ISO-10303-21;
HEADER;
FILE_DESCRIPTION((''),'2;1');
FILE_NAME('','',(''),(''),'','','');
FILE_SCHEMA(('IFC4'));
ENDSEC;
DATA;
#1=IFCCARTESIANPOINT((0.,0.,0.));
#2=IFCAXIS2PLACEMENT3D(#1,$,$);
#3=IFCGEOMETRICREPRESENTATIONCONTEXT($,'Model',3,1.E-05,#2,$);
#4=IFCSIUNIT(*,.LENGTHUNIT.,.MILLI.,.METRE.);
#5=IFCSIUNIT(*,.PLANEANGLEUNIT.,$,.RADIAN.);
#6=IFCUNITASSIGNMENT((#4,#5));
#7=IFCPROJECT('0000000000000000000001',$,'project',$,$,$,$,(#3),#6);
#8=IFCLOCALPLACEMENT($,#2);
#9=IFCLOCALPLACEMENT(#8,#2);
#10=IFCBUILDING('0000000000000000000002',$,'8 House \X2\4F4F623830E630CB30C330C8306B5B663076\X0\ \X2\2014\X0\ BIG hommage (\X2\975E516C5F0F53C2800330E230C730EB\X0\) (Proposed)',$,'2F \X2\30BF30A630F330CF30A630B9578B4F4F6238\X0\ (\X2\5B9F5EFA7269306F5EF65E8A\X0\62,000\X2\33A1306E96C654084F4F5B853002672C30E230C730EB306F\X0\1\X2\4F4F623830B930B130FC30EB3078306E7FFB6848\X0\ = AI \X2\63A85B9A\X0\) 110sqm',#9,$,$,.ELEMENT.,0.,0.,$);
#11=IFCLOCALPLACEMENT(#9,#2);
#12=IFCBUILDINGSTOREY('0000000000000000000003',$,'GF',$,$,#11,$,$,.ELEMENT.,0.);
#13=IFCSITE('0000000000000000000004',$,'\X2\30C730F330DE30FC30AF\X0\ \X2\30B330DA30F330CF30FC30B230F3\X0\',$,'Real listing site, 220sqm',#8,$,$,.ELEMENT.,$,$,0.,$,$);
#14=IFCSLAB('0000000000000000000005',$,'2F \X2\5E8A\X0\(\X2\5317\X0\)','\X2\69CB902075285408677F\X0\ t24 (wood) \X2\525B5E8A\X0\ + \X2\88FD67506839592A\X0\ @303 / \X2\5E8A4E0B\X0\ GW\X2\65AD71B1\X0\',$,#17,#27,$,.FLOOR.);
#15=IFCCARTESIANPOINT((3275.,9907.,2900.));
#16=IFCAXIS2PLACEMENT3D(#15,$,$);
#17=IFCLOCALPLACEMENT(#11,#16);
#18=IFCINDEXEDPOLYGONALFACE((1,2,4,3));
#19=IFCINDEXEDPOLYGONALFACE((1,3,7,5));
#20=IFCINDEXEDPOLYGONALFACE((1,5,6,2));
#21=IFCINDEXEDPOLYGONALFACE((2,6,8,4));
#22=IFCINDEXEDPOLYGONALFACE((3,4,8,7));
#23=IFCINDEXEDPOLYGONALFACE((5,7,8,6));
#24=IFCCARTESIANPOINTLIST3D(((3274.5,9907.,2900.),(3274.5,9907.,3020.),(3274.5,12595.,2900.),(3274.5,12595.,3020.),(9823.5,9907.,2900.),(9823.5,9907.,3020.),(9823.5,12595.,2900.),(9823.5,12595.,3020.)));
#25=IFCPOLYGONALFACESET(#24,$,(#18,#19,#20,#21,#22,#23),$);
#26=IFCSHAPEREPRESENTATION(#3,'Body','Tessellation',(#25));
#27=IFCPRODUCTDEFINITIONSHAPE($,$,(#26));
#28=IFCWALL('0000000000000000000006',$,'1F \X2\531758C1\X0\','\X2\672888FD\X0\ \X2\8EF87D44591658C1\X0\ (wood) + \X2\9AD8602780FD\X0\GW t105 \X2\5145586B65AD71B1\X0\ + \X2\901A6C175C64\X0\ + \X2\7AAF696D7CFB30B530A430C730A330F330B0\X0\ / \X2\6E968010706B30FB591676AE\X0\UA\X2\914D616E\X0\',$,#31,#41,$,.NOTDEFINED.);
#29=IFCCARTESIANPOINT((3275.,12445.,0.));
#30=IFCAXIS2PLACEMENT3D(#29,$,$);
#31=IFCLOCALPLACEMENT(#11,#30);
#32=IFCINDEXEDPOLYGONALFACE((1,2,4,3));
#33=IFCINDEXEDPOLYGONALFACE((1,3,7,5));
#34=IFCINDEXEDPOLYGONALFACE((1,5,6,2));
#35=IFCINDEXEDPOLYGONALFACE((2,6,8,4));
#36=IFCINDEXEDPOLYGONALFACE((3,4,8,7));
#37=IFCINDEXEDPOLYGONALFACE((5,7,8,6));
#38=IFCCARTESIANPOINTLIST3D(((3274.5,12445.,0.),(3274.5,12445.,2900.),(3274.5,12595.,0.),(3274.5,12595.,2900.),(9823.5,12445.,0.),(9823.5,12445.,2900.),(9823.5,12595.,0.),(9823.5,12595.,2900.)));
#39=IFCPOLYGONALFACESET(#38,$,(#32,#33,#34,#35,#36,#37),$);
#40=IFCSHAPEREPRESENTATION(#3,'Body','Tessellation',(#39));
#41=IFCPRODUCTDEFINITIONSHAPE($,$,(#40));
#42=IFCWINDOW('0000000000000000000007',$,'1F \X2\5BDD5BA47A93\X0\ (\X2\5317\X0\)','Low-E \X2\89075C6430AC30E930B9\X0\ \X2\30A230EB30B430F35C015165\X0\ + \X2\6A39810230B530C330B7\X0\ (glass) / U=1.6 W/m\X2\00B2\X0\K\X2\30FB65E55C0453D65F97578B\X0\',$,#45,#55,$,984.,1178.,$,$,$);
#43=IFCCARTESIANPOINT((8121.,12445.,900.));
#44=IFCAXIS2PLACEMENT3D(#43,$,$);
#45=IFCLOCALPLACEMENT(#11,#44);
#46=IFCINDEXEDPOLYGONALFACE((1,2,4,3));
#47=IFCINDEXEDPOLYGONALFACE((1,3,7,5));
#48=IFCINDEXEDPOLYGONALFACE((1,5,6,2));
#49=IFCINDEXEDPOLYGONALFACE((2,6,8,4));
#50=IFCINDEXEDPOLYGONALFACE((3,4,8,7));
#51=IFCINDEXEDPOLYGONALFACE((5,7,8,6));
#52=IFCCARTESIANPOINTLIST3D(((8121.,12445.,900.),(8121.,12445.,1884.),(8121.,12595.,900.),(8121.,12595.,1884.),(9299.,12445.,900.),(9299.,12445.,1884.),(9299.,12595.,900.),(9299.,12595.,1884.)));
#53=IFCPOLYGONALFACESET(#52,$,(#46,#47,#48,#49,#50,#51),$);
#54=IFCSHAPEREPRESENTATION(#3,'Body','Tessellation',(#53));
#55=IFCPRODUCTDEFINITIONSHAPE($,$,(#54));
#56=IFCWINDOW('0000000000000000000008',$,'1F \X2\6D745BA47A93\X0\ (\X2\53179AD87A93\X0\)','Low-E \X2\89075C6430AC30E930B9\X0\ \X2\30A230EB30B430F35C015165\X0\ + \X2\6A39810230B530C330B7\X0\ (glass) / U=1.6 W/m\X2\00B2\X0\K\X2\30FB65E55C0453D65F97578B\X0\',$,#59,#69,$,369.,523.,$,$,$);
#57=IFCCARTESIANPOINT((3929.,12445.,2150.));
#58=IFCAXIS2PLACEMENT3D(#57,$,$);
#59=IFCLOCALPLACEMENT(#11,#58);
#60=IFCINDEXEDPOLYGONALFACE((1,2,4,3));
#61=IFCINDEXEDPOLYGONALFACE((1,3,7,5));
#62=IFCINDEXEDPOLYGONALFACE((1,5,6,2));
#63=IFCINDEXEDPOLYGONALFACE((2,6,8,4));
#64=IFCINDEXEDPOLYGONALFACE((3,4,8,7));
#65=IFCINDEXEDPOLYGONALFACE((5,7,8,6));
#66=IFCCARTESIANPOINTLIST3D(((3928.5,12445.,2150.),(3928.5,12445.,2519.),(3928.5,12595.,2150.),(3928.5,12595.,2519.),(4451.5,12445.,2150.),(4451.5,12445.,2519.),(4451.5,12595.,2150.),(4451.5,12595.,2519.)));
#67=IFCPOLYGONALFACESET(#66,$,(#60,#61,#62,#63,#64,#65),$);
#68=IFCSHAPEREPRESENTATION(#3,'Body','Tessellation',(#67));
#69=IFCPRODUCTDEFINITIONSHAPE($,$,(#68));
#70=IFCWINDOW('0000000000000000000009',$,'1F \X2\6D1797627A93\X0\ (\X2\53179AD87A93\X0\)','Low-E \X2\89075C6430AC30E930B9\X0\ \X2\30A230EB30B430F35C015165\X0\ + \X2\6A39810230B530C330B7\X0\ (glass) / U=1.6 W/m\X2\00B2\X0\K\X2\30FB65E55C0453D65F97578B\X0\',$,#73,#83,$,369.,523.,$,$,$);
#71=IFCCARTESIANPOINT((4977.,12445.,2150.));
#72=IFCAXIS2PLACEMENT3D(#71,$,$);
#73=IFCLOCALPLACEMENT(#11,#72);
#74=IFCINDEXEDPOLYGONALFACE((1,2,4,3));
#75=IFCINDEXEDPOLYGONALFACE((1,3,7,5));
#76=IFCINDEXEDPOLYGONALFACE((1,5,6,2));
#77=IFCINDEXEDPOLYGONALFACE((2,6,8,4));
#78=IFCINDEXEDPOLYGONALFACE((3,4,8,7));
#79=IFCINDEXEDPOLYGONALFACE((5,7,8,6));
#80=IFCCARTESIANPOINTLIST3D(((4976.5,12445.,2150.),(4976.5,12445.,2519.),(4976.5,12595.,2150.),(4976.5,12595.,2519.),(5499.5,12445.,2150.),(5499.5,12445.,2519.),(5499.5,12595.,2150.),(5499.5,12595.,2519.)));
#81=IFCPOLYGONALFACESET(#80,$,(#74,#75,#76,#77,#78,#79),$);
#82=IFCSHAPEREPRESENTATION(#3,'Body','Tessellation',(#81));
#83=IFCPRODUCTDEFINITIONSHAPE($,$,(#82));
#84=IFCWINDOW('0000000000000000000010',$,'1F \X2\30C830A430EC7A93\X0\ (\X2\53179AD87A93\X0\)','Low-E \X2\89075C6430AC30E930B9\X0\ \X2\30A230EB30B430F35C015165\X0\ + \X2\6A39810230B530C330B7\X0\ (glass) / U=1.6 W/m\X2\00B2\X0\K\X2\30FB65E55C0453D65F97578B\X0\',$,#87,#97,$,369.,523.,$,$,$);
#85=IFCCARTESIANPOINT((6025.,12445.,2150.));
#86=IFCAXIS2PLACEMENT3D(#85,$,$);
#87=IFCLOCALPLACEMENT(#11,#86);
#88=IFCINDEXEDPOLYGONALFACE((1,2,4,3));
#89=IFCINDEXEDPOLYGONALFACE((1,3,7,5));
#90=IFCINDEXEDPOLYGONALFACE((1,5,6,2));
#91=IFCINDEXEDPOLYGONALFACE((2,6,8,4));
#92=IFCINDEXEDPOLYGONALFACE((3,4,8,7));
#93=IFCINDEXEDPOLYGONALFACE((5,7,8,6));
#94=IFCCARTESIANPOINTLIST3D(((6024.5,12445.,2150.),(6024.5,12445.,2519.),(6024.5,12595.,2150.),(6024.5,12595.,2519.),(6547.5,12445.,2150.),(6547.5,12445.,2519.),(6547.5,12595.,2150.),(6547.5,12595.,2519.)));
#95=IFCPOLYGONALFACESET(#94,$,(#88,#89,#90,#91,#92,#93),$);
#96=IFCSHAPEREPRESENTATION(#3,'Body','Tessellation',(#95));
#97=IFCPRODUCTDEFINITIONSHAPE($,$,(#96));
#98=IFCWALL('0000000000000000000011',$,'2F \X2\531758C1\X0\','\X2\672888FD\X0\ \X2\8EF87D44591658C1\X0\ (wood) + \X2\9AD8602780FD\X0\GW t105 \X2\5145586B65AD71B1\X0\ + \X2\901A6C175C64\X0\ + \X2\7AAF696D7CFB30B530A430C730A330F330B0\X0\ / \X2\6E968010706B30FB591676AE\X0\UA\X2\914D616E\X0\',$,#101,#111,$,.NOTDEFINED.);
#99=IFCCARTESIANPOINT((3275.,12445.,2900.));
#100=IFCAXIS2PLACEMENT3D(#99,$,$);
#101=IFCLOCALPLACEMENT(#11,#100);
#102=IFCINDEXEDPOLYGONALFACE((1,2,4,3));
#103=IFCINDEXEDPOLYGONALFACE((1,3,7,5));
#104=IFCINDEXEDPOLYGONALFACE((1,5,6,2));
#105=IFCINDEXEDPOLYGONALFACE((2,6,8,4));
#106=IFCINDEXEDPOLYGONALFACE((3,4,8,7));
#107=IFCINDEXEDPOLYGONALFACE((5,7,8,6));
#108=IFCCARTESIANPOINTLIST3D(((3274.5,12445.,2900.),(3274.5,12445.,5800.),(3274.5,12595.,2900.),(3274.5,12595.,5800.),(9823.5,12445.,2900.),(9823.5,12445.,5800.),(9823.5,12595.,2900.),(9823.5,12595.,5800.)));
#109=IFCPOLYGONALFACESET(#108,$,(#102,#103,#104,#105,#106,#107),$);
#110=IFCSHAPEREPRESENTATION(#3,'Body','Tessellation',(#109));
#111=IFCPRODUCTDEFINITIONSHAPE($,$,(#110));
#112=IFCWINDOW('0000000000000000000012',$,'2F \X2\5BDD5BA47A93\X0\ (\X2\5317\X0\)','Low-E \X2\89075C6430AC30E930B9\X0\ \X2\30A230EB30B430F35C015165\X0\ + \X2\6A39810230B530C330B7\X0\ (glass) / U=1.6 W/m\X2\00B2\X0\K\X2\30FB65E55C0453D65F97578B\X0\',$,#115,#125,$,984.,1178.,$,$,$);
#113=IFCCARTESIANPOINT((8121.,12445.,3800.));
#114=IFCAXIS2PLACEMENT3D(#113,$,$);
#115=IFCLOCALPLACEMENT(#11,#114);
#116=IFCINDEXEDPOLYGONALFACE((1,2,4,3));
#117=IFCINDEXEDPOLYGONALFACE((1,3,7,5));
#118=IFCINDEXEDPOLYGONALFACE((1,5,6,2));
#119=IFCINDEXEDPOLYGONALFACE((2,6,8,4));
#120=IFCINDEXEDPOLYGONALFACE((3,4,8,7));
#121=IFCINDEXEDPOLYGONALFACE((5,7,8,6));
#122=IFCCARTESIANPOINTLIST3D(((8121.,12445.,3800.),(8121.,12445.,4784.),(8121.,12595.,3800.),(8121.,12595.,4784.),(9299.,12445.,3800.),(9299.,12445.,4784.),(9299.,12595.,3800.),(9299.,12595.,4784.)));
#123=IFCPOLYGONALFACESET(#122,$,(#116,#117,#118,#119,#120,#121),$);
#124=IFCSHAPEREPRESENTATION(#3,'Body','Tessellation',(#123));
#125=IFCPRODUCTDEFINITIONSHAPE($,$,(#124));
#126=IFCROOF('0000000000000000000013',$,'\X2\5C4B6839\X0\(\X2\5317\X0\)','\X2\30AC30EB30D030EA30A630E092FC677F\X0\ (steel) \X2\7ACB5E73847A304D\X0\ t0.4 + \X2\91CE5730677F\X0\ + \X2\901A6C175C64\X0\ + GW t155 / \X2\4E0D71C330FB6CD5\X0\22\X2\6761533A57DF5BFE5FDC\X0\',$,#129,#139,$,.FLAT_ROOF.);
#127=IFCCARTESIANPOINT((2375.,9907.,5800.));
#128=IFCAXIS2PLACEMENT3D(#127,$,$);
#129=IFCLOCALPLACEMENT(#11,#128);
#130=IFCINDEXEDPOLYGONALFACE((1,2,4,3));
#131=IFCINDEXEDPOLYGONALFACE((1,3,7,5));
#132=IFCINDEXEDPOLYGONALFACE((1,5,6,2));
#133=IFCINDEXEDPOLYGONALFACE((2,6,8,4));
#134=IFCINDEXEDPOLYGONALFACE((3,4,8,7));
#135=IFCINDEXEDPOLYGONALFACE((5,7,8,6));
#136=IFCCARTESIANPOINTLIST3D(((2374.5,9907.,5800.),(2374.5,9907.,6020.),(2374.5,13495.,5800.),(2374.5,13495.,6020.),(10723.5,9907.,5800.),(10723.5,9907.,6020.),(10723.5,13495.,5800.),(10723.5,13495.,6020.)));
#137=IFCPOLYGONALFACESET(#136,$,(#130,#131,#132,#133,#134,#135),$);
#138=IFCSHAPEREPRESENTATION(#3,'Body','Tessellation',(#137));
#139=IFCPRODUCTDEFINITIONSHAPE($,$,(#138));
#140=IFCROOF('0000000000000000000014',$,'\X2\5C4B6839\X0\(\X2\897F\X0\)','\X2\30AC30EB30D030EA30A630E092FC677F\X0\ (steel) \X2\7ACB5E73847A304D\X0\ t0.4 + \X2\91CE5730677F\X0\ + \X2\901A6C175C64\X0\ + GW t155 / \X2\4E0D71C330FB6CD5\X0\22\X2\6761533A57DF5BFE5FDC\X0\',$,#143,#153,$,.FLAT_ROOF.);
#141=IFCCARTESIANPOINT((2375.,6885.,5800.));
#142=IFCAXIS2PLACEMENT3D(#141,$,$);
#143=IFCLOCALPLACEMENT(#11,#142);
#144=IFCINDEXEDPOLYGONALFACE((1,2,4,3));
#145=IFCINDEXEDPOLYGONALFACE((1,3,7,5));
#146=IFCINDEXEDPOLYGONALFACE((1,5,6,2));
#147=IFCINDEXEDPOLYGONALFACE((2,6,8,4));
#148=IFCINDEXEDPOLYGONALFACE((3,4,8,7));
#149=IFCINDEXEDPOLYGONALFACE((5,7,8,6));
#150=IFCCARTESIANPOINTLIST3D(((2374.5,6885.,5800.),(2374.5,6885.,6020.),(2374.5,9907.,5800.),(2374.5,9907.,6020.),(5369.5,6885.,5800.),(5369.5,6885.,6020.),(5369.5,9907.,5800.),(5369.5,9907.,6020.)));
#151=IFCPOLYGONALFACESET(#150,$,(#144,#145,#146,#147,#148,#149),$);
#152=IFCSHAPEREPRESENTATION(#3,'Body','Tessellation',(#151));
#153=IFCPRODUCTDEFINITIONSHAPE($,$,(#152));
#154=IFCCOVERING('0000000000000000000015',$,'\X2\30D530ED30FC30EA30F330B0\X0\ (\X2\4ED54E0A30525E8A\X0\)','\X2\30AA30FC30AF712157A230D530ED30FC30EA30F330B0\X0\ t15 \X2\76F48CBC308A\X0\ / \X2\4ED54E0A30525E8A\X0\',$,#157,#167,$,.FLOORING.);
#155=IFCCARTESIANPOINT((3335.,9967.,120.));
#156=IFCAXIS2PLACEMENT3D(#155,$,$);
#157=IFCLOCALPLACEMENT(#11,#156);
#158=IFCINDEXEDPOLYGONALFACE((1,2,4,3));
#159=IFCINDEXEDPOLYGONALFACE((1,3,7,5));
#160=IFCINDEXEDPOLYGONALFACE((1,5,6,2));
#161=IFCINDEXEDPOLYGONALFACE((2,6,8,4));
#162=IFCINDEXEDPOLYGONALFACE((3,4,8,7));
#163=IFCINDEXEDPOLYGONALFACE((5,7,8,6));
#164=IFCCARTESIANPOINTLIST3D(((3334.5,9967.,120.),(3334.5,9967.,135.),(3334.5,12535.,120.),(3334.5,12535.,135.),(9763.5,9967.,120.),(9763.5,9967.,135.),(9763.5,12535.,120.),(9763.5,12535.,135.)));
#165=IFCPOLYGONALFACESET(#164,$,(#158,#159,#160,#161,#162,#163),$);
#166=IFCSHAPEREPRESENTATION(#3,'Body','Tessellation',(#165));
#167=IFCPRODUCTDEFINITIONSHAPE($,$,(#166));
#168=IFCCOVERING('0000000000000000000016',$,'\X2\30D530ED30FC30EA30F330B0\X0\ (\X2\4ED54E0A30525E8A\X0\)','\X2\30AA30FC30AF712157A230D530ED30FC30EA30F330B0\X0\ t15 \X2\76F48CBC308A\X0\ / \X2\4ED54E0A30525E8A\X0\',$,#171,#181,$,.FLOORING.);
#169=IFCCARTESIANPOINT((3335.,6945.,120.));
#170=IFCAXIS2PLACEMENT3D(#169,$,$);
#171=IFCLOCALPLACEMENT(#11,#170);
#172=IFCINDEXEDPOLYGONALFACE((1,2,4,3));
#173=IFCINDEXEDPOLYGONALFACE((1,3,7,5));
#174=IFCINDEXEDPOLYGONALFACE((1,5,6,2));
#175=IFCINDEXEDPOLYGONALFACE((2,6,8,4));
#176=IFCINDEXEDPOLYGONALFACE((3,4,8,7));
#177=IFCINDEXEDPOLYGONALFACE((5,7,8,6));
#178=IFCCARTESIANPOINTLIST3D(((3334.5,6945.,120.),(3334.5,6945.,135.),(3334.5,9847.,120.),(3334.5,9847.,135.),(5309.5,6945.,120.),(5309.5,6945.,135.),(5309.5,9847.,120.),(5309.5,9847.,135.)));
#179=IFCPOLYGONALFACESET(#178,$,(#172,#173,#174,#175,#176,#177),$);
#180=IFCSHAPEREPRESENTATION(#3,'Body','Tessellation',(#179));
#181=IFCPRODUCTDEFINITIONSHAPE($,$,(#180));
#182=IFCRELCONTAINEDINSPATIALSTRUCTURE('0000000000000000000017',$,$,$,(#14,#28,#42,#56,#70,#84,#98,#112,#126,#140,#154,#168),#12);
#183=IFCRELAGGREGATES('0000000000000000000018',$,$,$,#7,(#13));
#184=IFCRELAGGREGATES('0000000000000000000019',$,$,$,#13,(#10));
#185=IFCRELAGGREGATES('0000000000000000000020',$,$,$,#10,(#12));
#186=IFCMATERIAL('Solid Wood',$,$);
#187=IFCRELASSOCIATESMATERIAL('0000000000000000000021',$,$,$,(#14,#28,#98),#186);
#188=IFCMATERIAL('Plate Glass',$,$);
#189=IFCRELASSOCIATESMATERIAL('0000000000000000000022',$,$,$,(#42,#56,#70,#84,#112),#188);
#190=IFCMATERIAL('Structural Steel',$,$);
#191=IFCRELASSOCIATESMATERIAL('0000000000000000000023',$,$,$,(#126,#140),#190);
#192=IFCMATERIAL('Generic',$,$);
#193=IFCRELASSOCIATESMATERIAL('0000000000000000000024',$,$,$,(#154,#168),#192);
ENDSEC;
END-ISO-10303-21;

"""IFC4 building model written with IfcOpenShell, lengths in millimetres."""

from ifc_helpers import new_model, si_unit, frame, frame_2d, origin, place, context, project, spatial, rectangle, extrude, material, element, fill, save


model = new_model("IFC4")

# Units and contexts
model_context = context("Model", 3, precision=1e-05, world=origin())
ifc_project = project(units=[si_unit("LENGTHUNIT", "METRE", prefix="MILLI"), si_unit("PLANEANGLEUNIT", "RADIAN")], contexts=[model_context])

# Site, building, storey
site_placement = place(None, origin())
site = spatial("IfcSite", under=ifc_project, at=site_placement, Name="デンマーク コペンハーゲン", ObjectType="Real listing site, 220sqm", CompositionType="ELEMENT", RefElevation=0.0)
building_placement = place(site_placement, origin())
building = spatial("IfcBuilding", under=site, at=building_placement, Name="8 House 住戸ユニットに学ぶ — BIG hommage (非公式参考モデル) (Proposed)", ObjectType="2F タウンハウス型住戸 (実建物は延床62,000㎡の集合住宅。本モデルは1住戸スケールへの翻案 = AI 推定) 110sqm", CompositionType="ELEMENT", ElevationOfRefHeight=0.0, ElevationOfTerrain=0.0)
storey_placement = place(building_placement, origin())
storey = spatial("IfcBuildingStorey", under=building, at=storey_placement, Name="GF", CompositionType="ELEMENT", Elevation=0.0)

# Slab
ifc_material_1 = material(Name="Solid Wood")
slab_1_placement = place(storey_placement, frame((3275.0, 9907.0, 2900.0)))
element("IfcSlab", 1, at=slab_1_placement, inside=storey, material=ifc_material_1, Name="2F 床(北)", Description="構造用合板 t24 (wood) 剛床 + 製材根太 @303 / 床下 GW断熱", PredefinedType="FLOOR", context=model_context, shape_type="SweptSolid", body=[
    extrude(rectangle(XDim=6549.0, YDim=2688.0, at=frame_2d((3274.0, 1344.0))), frame((3275.0, 9907.0, 2900.0)), (0.0, 0.0, 1.0), 120.0),
])

# Wall, openings, windows
wall_1_placement = place(storey_placement, frame((3275.0, 12445.0, 0.0)))
wall_1 = element("IfcWall", 2, at=wall_1_placement, inside=storey, material=ifc_material_1, Name="1F 北壁", Description="木製 軸組外壁 (wood) + 高性能GW t105 充填断熱 + 通気層 + 窯業系サイディング / 準耐火・外皮UA配慮", PredefinedType="NOTDEFINED", context=model_context, shape_type="SweptSolid", body=[
    extrude(rectangle(XDim=6549.0, YDim=150.0, at=frame_2d((3274.0, 75.0))), frame((3275.0, 12445.0, 0.0)), (0.0, 0.0, 1.0), 2900.0),
])
opening_1_placement = place(storey_placement, frame((8121.0, 12445.0, 900.0)))
opening_1 = element("IfcOpeningElement", 3, at=opening_1_placement, cuts=wall_1, PredefinedType="NOTDEFINED", context=model_context, shape_type="SweptSolid", body=[
    extrude(rectangle(XDim=1178.0, YDim=150.0, at=frame_2d((589.0, 75.0))), frame((8121.0, 12445.0, 900.0)), (0.0, 0.0, 1.0), 984.0),
])
opening_2_placement = place(storey_placement, frame((3929.0, 12445.0, 2150.0)))
opening_2 = element("IfcOpeningElement", 4, at=opening_2_placement, cuts=wall_1, PredefinedType="NOTDEFINED", context=model_context, shape_type="SweptSolid", body=[
    extrude(rectangle(XDim=523.0, YDim=150.0, at=frame_2d((261.0, 75.0))), frame((3929.0, 12445.0, 2150.0)), (0.0, 0.0, 1.0), 369.0),
])
opening_3_placement = place(storey_placement, frame((4977.0, 12445.0, 2150.0)))
opening_3 = element("IfcOpeningElement", 5, at=opening_3_placement, cuts=wall_1, PredefinedType="NOTDEFINED", context=model_context, shape_type="SweptSolid", body=[
    extrude(rectangle(XDim=523.0, YDim=150.0, at=frame_2d((261.0, 75.0))), frame((4977.0, 12445.0, 2150.0)), (0.0, 0.0, 1.0), 369.0),
])
opening_4_placement = place(storey_placement, frame((6025.0, 12445.0, 2150.0)))
opening_4 = element("IfcOpeningElement", 6, at=opening_4_placement, cuts=wall_1, PredefinedType="NOTDEFINED", context=model_context, shape_type="SweptSolid", body=[
    extrude(rectangle(XDim=523.0, YDim=150.0, at=frame_2d((261.0, 75.0))), frame((6025.0, 12445.0, 2150.0)), (0.0, 0.0, 1.0), 369.0),
])
ifc_material_2 = material(Name="Plate Glass")
window_1_placement = place(storey_placement, frame((8121.0, 12445.0, 900.0)))
window_1 = element("IfcWindow", 7, at=window_1_placement, inside=storey, material=ifc_material_2, Name="1F 寝室窓 (北)", Description="Low-E 複層ガラス アルゴン封入 + 樹脂サッシ (glass) / U=1.6 W/m²K・日射取得型", OverallHeight=984.0, OverallWidth=1178.0, context=model_context, shape_type="SweptSolid", body=[
    extrude(rectangle(XDim=1178.0, YDim=150.0, at=frame_2d((589.0, 75.0))), frame((8121.0, 12445.0, 900.0)), (0.0, 0.0, 1.0), 984.0),
])
fill(opening_1, window_1)
window_2_placement = place(storey_placement, frame((3929.0, 12445.0, 2150.0)))
window_2 = element("IfcWindow", 8, at=window_2_placement, inside=storey, material=ifc_material_2, Name="1F 浴室窓 (北高窓)", Description="Low-E 複層ガラス アルゴン封入 + 樹脂サッシ (glass) / U=1.6 W/m²K・日射取得型", OverallHeight=369.0, OverallWidth=523.0, context=model_context, shape_type="SweptSolid", body=[
    extrude(rectangle(XDim=523.0, YDim=150.0, at=frame_2d((261.0, 75.0))), frame((3929.0, 12445.0, 2150.0)), (0.0, 0.0, 1.0), 369.0),
])
fill(opening_2, window_2)
window_3_placement = place(storey_placement, frame((4977.0, 12445.0, 2150.0)))
window_3 = element("IfcWindow", 9, at=window_3_placement, inside=storey, material=ifc_material_2, Name="1F 洗面窓 (北高窓)", Description="Low-E 複層ガラス アルゴン封入 + 樹脂サッシ (glass) / U=1.6 W/m²K・日射取得型", OverallHeight=369.0, OverallWidth=523.0, context=model_context, shape_type="SweptSolid", body=[
    extrude(rectangle(XDim=523.0, YDim=150.0, at=frame_2d((261.0, 75.0))), frame((4977.0, 12445.0, 2150.0)), (0.0, 0.0, 1.0), 369.0),
])
fill(opening_3, window_3)
window_4_placement = place(storey_placement, frame((6025.0, 12445.0, 2150.0)))
window_4 = element("IfcWindow", 10, at=window_4_placement, inside=storey, material=ifc_material_2, Name="1F トイレ窓 (北高窓)", Description="Low-E 複層ガラス アルゴン封入 + 樹脂サッシ (glass) / U=1.6 W/m²K・日射取得型", OverallHeight=369.0, OverallWidth=523.0, context=model_context, shape_type="SweptSolid", body=[
    extrude(rectangle(XDim=523.0, YDim=150.0, at=frame_2d((261.0, 75.0))), frame((6025.0, 12445.0, 2150.0)), (0.0, 0.0, 1.0), 369.0),
])
fill(opening_4, window_4)

# Wall, opening, window
wall_2_placement = place(storey_placement, frame((3275.0, 12445.0, 2900.0)))
wall_2 = element("IfcWall", 11, at=wall_2_placement, inside=storey, material=ifc_material_1, Name="2F 北壁", Description="木製 軸組外壁 (wood) + 高性能GW t105 充填断熱 + 通気層 + 窯業系サイディング / 準耐火・外皮UA配慮", PredefinedType="NOTDEFINED", context=model_context, shape_type="SweptSolid", body=[
    extrude(rectangle(XDim=6549.0, YDim=150.0, at=frame_2d((3274.0, 75.0))), frame((3275.0, 12445.0, 2900.0)), (0.0, 0.0, 1.0), 2900.0),
])
opening_5_placement = place(storey_placement, frame((8121.0, 12445.0, 3800.0)))
opening_5 = element("IfcOpeningElement", 12, at=opening_5_placement, cuts=wall_2, PredefinedType="NOTDEFINED", context=model_context, shape_type="SweptSolid", body=[
    extrude(rectangle(XDim=1178.0, YDim=150.0, at=frame_2d((589.0, 75.0))), frame((8121.0, 12445.0, 3800.0)), (0.0, 0.0, 1.0), 984.0),
])
window_5_placement = place(storey_placement, frame((8121.0, 12445.0, 3800.0)))
window_5 = element("IfcWindow", 13, at=window_5_placement, inside=storey, material=ifc_material_2, Name="2F 寝室窓 (北)", Description="Low-E 複層ガラス アルゴン封入 + 樹脂サッシ (glass) / U=1.6 W/m²K・日射取得型", OverallHeight=984.0, OverallWidth=1178.0, context=model_context, shape_type="SweptSolid", body=[
    extrude(rectangle(XDim=1178.0, YDim=150.0, at=frame_2d((589.0, 75.0))), frame((8121.0, 12445.0, 3800.0)), (0.0, 0.0, 1.0), 984.0),
])
fill(opening_5, window_5)

# Roofs
ifc_material_3 = material(Name="Structural Steel")
for number, where, name in (
    (14, (2375.0, 9907.0, 5800.0), "屋根(北)"),
):
    element("IfcRoof", number, at=place(storey_placement, frame(where)), inside=storey, material=ifc_material_3, Name=name, Description="ガルバリウム鋼板 (steel) 立平葺き t0.4 + 野地板 + 通気層 + GW t155 / 不燃・法22条区域対応", PredefinedType="FLAT_ROOF", context=model_context, shape_type="SweptSolid", body=[
        extrude(rectangle(XDim=8349.0, YDim=3588.0, at=frame_2d((4174.0, 1794.0))), frame((2375.0, 9907.0, 5800.0)), (0.0, 0.0, 1.0), 220.0),
    ])
roof_placement = place(storey_placement, frame((2375.0, 6885.0, 5800.0)))
element("IfcRoof", 15, at=roof_placement, inside=storey, material=ifc_material_3, Name="屋根(西)", Description="ガルバリウム鋼板 (steel) 立平葺き t0.4 + 野地板 + 通気層 + GW t155 / 不燃・法22条区域対応", PredefinedType="FLAT_ROOF", context=model_context, shape_type="SweptSolid", body=[
    extrude(rectangle(XDim=2995.0, YDim=3022.0, at=frame_2d((1497.0, 1511.0))), frame((2375.0, 6885.0, 5800.0)), (0.0, 0.0, 1.0), 220.0),
])

# Coverings
ifc_material_4 = material(Name="Generic")
covering_1_placement = place(storey_placement, frame((3335.0, 9967.0, 120.0)))
element("IfcCovering", 16, at=covering_1_placement, inside=storey, material=ifc_material_4, Name="フローリング (仕上げ床)", Description="オーク無垢フローリング t15 直貼り / 仕上げ床", PredefinedType="FLOORING", context=model_context, shape_type="SweptSolid", body=[
    extrude(rectangle(XDim=6429.0, YDim=2568.0, at=frame_2d((3214.0, 1284.0))), frame((3335.0, 9967.0, 120.0)), (0.0, 0.0, 1.0), 15.0),
])
covering_2_placement = place(storey_placement, frame((3335.0, 6945.0, 120.0)))
element("IfcCovering", 17, at=covering_2_placement, inside=storey, material=ifc_material_4, Name="フローリング (仕上げ床)", Description="オーク無垢フローリング t15 直貼り / 仕上げ床", PredefinedType="FLOORING", context=model_context, shape_type="SweptSolid", body=[
    extrude(rectangle(XDim=1975.0, YDim=2902.0, at=frame_2d((987.0, 1451.0))), frame((3335.0, 6945.0, 120.0)), (0.0, 0.0, 1.0), 15.0),
])

save(model, "model.ifc")
